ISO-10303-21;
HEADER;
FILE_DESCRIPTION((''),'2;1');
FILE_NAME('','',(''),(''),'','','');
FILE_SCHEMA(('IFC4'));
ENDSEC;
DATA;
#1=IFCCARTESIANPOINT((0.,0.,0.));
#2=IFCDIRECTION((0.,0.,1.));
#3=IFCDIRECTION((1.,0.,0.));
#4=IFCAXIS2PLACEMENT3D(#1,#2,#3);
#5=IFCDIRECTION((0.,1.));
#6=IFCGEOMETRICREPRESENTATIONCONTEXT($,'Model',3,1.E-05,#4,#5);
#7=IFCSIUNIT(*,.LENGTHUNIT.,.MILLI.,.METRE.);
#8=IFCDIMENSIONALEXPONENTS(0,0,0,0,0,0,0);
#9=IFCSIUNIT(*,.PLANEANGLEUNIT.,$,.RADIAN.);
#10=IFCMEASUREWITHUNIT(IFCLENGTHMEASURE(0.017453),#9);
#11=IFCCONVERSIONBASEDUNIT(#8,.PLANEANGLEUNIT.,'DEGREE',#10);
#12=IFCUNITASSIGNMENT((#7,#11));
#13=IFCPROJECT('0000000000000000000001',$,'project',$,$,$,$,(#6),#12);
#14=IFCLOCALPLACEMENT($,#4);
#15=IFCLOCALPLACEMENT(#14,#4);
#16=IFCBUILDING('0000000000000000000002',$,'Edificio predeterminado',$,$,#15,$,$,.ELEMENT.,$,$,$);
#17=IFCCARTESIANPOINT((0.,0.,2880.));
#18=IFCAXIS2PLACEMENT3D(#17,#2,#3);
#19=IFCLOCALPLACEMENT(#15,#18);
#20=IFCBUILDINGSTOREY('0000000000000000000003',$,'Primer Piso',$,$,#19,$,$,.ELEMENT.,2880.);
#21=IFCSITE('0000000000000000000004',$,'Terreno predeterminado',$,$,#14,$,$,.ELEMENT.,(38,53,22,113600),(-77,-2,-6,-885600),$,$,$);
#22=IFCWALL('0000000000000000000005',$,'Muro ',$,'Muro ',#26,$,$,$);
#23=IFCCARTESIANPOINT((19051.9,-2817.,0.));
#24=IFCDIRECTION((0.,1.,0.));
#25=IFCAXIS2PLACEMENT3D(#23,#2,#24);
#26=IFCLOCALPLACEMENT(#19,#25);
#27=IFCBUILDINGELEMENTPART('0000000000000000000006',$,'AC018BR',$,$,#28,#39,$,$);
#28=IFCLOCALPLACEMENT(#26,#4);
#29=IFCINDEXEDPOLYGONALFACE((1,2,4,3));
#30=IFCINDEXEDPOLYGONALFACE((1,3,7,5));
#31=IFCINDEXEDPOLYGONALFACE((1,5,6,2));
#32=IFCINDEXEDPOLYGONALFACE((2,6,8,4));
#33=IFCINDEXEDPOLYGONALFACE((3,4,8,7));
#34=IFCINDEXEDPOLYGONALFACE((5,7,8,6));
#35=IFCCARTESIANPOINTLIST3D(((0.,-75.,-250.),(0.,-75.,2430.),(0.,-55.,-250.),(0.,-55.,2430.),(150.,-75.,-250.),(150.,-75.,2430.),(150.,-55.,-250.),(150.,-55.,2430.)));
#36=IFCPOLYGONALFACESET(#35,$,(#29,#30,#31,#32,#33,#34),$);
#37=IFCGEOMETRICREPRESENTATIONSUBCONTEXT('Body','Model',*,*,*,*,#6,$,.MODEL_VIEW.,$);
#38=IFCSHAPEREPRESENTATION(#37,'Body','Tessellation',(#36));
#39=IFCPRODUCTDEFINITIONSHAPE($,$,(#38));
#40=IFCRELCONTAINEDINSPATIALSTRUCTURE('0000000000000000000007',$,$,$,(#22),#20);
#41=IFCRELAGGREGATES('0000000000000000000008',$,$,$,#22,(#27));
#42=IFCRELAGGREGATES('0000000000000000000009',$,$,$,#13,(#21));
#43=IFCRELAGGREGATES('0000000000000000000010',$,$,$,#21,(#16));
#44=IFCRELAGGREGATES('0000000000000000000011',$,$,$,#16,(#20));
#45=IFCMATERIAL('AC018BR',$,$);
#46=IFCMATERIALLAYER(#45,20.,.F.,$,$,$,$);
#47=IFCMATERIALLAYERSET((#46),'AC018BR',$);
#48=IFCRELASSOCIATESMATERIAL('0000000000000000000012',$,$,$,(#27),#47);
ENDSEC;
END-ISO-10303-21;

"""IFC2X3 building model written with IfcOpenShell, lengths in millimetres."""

from ifc_helpers import new_model, entity, si_unit, converted_unit, direction, frame, origin_with_axes, place, context, subcontext, project, spatial, polyline, outline, extrude, clip, bounded_halfspace, material, layer, layer_set, layer_usage, element, aggregate, save


model = new_model("IFC2X3")

# Units and contexts
model_context = context("Model", 3, precision=1e-05, world=origin_with_axes(), true_north=direction((0.0, 1.0)))
body_context = subcontext(model_context, "Body", "Model", "MODEL_VIEW")
ifc_project = project(units=[si_unit("LENGTHUNIT", "METRE", prefix="MILLI"), converted_unit("PLANEANGLEUNIT", "DEGREE", entity("IfcLengthMeasure", 0.017453), si_unit("PLANEANGLEUNIT", "RADIAN"), dimensions=[0, 0, 0, 0, 0, 0, 0])], contexts=[model_context])

# Site, building, storey
site_placement = place(None, origin_with_axes())
site = spatial("IfcSite", under=ifc_project, at=site_placement, Name="Terreno predeterminado", CompositionType="ELEMENT", RefLatitude=(38, 53, 22, 113600), RefLongitude=(-77, -2, -6, -885600))
building_placement = place(site_placement, origin_with_axes())
building = spatial("IfcBuilding", under=site, at=building_placement, Name="Edificio predeterminado", CompositionType="ELEMENT")
storey_placement = place(building_placement, frame((0.0, 0.0, 2880.0), z_axis=(0.0, 0.0, 1.0), x_axis=(1.0, 0.0, 0.0)))
storey = spatial("IfcBuildingStorey", under=building, at=storey_placement, Name="Primer Piso", CompositionType="ELEMENT", Elevation=2880.0)

# Wall, building element part
wall_1_placement = place(storey_placement, frame((19051.9, -2817.0, 0.0), z_axis=(0.0, 0.0, 1.0), x_axis=(0.0, 1.0, 0.0)))
wall_1 = element("IfcWall", 1, at=wall_1_placement, inside=storey, Name="Muro ", ObjectType="Muro ")
ifc_material_1 = material(Name="AC018BR")
ifc_layer_1 = layer(ifc_material_1, 20.0, ventilated=False)
ifc_layer_set_1 = layer_set([ifc_layer_1], Name="AC018BR")
ifc_layer_usage_1 = layer_usage(ifc_layer_set_1, "AXIS2", "NEGATIVE", 55.0)
building_element_part_1_placement = place(wall_1_placement, origin_with_axes())
building_element_part_1 = element("IfcBuildingElementPart", 2, at=building_element_part_1_placement, material=ifc_layer_usage_1, Name="AC018BR", context=body_context, shape_type="Clipping", body=[
    clip(clip(extrude(outline(polyline([(150.0, -55.0), (150.0, -75.0), (0.0, -75.0), (0.0, -55.0), (150.0, -55.0)])), frame((0.0, 0.0, -250.0), z_axis=(0.0, 0.0, 1.0), x_axis=(1.0, 0.0, 0.0)), (0.0, 0.0, 1.0), 2680.0), bounded_halfspace(frame((0.0, 0.0, -250.0), z_axis=(0.0, 0.0, 1.0), x_axis=(1.0, 0.0, 0.0)), True, origin_with_axes(), polyline([(-150.0, -150.0), (375.0, -150.0), (375.0, 150.0), (-150.0, 150.0), (-150.0, -150.0)]))), bounded_halfspace(frame((0.0, 0.0, 2430.0), z_axis=(0.0, 0.0, 1.0), x_axis=(1.0, 0.0, 0.0)), False, origin_with_axes(), polyline([(-150.0, -150.0), (375.0, -150.0), (375.0, 150.0), (-150.0, 150.0), (-150.0, -150.0)]))),
])
aggregate(wall_1, [building_element_part_1])

save(model, "model.ifc")
